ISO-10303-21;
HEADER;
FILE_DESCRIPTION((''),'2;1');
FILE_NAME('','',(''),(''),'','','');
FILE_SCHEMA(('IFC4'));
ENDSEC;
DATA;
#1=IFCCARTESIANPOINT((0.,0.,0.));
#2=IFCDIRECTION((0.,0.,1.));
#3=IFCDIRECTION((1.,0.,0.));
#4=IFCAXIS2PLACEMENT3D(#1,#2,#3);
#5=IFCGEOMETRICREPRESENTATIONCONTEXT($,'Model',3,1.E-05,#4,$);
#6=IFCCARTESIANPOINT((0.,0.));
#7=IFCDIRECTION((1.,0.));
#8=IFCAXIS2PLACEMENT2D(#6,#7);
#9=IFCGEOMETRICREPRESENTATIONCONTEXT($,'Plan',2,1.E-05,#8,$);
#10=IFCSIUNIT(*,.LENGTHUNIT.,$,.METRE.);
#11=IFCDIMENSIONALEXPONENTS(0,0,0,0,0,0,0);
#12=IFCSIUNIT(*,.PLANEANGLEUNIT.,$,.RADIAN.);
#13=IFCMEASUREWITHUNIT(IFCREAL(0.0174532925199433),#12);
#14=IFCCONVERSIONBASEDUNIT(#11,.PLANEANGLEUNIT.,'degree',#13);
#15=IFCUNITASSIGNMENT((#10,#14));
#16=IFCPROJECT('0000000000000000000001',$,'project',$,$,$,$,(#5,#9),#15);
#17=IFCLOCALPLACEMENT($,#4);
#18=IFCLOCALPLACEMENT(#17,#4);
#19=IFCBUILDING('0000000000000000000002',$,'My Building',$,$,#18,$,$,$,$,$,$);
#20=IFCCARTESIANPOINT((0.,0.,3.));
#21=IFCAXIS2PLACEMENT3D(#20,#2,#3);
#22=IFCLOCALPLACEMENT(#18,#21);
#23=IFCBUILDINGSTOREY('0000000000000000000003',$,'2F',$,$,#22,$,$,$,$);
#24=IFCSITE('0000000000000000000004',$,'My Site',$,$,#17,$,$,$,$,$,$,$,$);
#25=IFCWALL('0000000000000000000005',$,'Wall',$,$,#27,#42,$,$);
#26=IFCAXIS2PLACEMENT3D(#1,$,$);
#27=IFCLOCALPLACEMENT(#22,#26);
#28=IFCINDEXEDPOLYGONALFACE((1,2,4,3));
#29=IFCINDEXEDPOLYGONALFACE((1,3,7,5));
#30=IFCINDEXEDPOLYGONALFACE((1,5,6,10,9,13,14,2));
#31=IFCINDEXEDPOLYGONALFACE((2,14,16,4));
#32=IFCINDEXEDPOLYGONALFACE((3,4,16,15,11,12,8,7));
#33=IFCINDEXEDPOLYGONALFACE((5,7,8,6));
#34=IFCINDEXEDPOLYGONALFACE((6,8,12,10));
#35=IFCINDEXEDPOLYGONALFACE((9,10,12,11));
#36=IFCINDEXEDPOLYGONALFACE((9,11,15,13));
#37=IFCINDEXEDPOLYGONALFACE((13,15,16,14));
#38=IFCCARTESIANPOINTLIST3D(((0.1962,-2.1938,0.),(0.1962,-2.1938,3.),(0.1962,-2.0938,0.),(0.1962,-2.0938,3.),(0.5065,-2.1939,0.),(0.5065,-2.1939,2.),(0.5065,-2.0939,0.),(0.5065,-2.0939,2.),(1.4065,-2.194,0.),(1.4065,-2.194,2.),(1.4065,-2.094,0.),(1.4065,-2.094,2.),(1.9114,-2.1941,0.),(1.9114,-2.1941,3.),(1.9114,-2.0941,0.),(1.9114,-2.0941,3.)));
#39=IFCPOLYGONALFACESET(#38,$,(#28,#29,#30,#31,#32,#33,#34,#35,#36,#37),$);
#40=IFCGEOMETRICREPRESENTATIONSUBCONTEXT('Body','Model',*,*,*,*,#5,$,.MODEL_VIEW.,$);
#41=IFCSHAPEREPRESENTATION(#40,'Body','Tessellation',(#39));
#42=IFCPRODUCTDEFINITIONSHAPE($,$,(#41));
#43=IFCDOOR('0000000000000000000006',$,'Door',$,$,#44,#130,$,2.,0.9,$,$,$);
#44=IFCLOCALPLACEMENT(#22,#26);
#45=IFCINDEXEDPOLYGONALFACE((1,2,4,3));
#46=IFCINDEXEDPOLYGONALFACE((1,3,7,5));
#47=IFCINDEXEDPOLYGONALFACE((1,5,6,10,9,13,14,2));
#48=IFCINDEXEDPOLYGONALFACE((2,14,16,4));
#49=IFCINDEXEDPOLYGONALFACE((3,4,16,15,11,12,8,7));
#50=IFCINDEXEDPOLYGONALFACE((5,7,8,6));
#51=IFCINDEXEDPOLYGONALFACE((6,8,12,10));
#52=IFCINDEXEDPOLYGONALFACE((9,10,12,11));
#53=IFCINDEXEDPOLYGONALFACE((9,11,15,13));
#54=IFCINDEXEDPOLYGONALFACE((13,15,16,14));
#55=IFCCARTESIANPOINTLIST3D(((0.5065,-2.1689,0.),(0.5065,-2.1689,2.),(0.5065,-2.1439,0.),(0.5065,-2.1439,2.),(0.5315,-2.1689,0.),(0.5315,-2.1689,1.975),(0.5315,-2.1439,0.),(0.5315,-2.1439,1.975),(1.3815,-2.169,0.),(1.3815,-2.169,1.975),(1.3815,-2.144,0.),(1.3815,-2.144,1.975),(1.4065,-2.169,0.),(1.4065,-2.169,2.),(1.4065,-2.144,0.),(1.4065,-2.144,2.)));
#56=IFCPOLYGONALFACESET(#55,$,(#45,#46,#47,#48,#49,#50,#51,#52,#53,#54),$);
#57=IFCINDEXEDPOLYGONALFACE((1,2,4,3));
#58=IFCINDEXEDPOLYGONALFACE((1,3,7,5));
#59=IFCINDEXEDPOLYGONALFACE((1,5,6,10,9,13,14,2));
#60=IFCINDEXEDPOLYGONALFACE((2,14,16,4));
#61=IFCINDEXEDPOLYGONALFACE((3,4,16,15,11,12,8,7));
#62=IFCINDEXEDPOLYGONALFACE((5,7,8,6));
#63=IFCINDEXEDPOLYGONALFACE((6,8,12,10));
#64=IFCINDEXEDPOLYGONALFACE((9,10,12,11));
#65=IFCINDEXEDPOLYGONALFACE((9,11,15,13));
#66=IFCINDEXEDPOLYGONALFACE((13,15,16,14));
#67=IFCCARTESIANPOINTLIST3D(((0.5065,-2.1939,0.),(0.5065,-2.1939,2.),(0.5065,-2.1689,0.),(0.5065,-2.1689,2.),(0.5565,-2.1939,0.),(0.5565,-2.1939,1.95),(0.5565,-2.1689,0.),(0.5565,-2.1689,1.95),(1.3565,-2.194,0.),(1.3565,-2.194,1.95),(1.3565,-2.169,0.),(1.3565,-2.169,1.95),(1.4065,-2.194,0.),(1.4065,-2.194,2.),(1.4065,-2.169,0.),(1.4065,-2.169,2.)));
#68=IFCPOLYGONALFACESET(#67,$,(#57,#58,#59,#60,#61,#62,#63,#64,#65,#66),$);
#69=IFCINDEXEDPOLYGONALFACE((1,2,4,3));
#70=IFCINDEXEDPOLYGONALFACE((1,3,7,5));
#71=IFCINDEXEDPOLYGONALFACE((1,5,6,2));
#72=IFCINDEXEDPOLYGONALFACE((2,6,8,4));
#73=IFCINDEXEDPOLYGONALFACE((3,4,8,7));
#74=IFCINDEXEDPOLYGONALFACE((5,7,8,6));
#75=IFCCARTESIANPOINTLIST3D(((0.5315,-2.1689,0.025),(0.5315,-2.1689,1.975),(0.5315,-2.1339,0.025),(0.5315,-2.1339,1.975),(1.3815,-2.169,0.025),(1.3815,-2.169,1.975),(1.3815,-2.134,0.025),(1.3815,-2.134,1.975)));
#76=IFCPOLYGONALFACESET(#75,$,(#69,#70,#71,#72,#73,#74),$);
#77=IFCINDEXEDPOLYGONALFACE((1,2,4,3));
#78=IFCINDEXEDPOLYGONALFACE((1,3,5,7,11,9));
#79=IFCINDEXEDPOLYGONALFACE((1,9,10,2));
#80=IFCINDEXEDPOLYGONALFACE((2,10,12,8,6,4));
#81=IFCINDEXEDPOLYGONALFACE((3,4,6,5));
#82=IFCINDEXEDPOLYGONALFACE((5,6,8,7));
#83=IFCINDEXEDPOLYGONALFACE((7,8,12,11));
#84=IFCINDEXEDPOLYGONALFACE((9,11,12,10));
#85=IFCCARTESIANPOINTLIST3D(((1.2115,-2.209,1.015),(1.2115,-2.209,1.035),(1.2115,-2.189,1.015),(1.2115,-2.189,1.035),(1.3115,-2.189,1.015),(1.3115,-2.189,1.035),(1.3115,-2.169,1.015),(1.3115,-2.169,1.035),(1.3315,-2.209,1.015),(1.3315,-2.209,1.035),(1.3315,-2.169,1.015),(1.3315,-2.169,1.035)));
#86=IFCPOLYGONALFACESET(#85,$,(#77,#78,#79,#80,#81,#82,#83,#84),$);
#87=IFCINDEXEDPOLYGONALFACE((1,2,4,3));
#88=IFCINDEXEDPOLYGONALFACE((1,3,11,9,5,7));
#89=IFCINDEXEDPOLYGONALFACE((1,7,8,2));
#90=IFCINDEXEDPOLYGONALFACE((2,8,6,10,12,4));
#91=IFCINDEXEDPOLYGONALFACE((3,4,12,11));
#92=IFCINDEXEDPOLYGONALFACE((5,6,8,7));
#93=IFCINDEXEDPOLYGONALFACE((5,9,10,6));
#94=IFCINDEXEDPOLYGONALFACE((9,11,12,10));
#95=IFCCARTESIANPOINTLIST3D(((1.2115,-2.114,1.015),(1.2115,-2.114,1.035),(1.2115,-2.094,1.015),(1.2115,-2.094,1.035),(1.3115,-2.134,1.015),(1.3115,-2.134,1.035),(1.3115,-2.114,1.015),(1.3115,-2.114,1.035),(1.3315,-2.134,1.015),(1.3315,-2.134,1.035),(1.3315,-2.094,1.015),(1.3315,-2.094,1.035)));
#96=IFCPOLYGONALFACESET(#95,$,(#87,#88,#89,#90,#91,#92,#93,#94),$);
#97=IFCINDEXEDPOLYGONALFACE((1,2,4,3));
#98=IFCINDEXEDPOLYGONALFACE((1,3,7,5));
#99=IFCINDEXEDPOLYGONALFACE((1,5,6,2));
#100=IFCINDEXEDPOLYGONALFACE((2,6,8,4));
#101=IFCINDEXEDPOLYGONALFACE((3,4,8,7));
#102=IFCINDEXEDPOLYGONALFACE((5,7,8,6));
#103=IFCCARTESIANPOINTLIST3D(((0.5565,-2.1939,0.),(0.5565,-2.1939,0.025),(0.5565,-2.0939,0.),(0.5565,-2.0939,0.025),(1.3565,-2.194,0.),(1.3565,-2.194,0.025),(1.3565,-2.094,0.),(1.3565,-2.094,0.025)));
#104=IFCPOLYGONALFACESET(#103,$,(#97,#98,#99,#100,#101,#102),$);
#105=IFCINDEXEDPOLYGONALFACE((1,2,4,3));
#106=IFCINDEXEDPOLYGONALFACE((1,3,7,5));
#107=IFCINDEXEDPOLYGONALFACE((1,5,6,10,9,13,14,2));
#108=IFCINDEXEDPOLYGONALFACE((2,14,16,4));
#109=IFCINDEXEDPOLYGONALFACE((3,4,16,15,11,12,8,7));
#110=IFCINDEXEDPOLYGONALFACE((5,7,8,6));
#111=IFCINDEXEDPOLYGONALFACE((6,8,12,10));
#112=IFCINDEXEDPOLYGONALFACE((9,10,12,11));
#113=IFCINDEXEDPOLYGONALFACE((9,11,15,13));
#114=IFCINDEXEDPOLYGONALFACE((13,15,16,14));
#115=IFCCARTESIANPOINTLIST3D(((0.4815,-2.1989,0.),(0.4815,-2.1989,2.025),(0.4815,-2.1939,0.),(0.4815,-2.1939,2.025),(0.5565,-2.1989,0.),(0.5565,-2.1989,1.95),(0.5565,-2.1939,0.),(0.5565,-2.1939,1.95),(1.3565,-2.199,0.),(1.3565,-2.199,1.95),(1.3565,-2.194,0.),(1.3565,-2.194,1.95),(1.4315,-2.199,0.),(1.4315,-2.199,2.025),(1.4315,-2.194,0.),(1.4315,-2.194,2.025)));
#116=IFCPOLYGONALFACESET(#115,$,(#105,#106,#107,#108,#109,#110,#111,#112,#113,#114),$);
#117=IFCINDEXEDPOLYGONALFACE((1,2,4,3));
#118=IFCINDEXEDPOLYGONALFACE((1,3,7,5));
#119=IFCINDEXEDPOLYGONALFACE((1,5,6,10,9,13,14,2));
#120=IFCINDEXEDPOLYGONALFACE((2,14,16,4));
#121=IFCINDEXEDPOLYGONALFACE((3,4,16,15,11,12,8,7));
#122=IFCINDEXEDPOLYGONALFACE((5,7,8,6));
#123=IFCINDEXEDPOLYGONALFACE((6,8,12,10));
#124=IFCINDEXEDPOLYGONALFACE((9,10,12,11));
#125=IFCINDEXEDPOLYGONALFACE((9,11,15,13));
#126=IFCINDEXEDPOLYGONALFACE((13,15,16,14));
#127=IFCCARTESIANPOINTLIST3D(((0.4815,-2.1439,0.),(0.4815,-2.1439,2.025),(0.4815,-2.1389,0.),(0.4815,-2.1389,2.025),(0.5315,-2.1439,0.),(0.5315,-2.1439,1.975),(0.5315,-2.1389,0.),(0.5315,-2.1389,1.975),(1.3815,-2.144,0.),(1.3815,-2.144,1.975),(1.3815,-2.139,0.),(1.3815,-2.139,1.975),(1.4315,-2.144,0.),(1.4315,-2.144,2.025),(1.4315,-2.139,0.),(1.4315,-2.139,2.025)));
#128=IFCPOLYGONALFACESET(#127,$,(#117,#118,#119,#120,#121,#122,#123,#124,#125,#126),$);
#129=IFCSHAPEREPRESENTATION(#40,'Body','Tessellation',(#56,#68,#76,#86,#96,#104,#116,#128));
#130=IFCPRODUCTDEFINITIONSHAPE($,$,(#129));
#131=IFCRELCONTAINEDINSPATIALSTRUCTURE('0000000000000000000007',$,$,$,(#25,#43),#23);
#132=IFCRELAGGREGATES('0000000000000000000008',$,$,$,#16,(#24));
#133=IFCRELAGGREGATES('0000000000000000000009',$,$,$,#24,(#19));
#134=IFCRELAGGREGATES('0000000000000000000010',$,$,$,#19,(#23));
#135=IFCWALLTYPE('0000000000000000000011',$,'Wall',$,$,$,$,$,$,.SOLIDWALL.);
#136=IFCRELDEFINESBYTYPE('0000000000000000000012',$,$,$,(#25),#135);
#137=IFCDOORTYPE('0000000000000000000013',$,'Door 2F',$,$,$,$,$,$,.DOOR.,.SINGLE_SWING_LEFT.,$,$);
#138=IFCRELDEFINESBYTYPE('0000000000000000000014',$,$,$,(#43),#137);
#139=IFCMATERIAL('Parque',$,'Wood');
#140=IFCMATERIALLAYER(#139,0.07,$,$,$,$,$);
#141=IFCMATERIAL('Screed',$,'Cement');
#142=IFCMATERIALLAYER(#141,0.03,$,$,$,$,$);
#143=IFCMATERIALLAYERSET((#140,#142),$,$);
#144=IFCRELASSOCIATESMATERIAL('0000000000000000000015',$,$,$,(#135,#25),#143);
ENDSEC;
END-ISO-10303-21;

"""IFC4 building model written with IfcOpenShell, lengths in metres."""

from ifc_helpers import new_model, entity, si_unit, converted_unit, frame, origin_with_axes, origin_2d_with_axis, place, context, subcontext, project, spatial, line, indexed_curve, outline, extrude, shape, source, transform, mapped, material, layer, layer_set, layer_usage, type_object, type_shapes, element, fill, save


model = new_model("IFC4")

# Units and contexts
model_context = context("Model", 3, precision=1e-05, world=origin_with_axes())
plan_context = context("Plan", 2, precision=1e-05, world=origin_2d_with_axis())
body_context_1 = subcontext(model_context, "Body", "Model", "MODEL_VIEW")
body_context_2 = subcontext(plan_context, "Body", "Plan", "PLAN_VIEW")
ifc_project = project(units=[si_unit("LENGTHUNIT", "METRE"), converted_unit("PLANEANGLEUNIT", "degree", entity("IfcReal", 0.0174532925199433), si_unit("PLANEANGLEUNIT", "RADIAN"), dimensions=[0, 0, 0, 0, 0, 0, 0])], contexts=[model_context, plan_context])

# Site, building, storey
site_placement = place(None, origin_with_axes())
site = spatial("IfcSite", under=ifc_project, at=site_placement, Name="My Site")
building_placement = place(site_placement, origin_with_axes())
building = spatial("IfcBuilding", under=site, at=building_placement, Name="My Building")
storey_placement = place(building_placement, frame((0.0, 0.0, 3.0), z_axis=(0.0, 0.0, 1.0), x_axis=(1.0, 0.0, 0.0)))
storey = spatial("IfcBuildingStorey", under=building, at=storey_placement, Name="2F")

# Shared definitions
ifc_material_1 = material(Name="Parque", Category="Wood")
ifc_layer_1 = layer(ifc_material_1, 0.07)
ifc_material_2 = material(Name="Screed", Category="Cement")
ifc_layer_2 = layer(ifc_material_2, 0.03)
ifc_layer_set_1 = layer_set([ifc_layer_1, ifc_layer_2])
wall_type = type_object("IfcWallType", Name="Wall", PredefinedType="SOLIDWALL", material=ifc_layer_set_1)

# Wall, opening, door
ifc_layer_usage_1 = layer_usage(ifc_layer_set_1, "AXIS2", "POSITIVE", 0.0)
wall_1_placement = place(storey_placement, frame((0.1962, -2.1938, 0.0), z_axis=(0.0, 0.0, 1.0), x_axis=(1.0, -0.00013, 0.0)))
wall_1 = element("IfcWall", 1, at=wall_1_placement, inside=storey, type_object=wall_type, material=ifc_layer_usage_1, Name="Wall", context=body_context_1, shape_type="SweptSolid", body=[
    extrude(outline(indexed_curve([(0.0, 0.0), (0.0, 0.1), (1.7152, 0.1), (1.7152, 0.0)], segments=[line(1, 2, 3, 4, 1)])), origin_with_axes(), (0.0, 0.0, 1.0), 3.0),
])
shared_shape_1 = source(origin_with_axes(), body_context_1, "Body", "SweptSolid", [
    extrude(outline(indexed_curve([(0.0, 0.0), (0.9, 0.0), (0.9, 2.0), (0.0, 2.0)], segments=[line(1, 2, 3, 4, 1)])), frame((0.0, -0.6, 0.0), z_axis=(0.0, -1.0, 0.0), x_axis=(1.0, 0.0, 0.0)), (0.0, 0.0, -1.0), 1.2),
])
opening_1_placement = place(wall_1_placement, frame((0.3103, 0.0, 0.0), z_axis=(0.0, 0.0, 1.0), x_axis=(1.0, 0.0, 0.0)))
opening_1 = element("IfcOpeningElement", 2, at=opening_1_placement, cuts=wall_1, PredefinedType="OPENING", context=body_context_1, shape_type="MappedRepresentation", body=[
    mapped(shared_shape_1, transform((0.0, 0.0, 0.0), x_axis=(1.0, 0.0, 0.0), y_axis=(0.0, 1.0, 0.0), z_axis=(0.0, 0.0, 1.0), scale=1.0)),
])
door_type_1 = type_object("IfcDoorType", Name="Door 2F", OperationType="SINGLE_SWING_LEFT", PredefinedType="DOOR")
shared_shape_2 = source(origin_with_axes(), body_context_1, "Body", "SweptSolid", [
    extrude(outline(indexed_curve([(0.0, 0.0), (0.0, 2.0), (0.9, 2.0), (0.9, 0.0), (0.875, 0.0), (0.875, 1.975), (0.025, 1.975), (0.025, 0.0)], segments=[line(1, 2, 3, 4, 5, 6, 7, 8, 1)])), frame((0.0, 0.025, 0.0), z_axis=(0.0, -1.0, 0.0), x_axis=(1.0, 0.0, 0.0)), (0.0, 0.0, -1.0), 0.025),
    extrude(outline(indexed_curve([(0.0, 0.0), (0.0, 2.0), (0.9, 2.0), (0.9, 0.0), (0.85, 0.0), (0.85, 1.95), (0.05, 1.95), (0.05, 0.0)], segments=[line(1, 2, 3, 4, 5, 6, 7, 8, 1)])), frame((0.0, 0.0, 0.0), z_axis=(0.0, -1.0, 0.0), x_axis=(1.0, 0.0, 0.0)), (0.0, 0.0, -1.0), 0.025),
    extrude(outline(indexed_curve([(0.0, 0.0), (0.85, 0.0), (0.85, 0.035), (0.0, 0.035)], segments=[line(1, 2, 3, 4, 1)])), frame((0.025, 0.025, 0.025), z_axis=(0.0, 0.0, 1.0), x_axis=(1.0, 0.0, 0.0)), (0.0, 0.0, 1.0), 1.95),
    extrude(outline(indexed_curve([(0.0, 0.0), (0.0, -0.04), (-0.12, -0.04), (-0.12, -0.02), (-0.02, -0.02), (-0.02, 0.0)], segments=[line(1, 2, 3, 4, 5, 6, 1)])), frame((0.825, 0.025, 1.015), z_axis=(0.0, 0.0, 1.0), x_axis=(1.0, 0.0, 0.0)), (0.0, 0.0, 1.0), 0.02),
    extrude(outline(indexed_curve([(0.0, 0.0), (0.0, 0.04), (-0.12, 0.04), (-0.12, 0.02), (-0.02, 0.02), (-0.02, 0.0)], segments=[line(1, 2, 3, 4, 5, 6, 1)])), frame((0.825, 0.06, 1.015), z_axis=(0.0, 0.0, 1.0), x_axis=(1.0, 0.0, 0.0)), (0.0, 0.0, 1.0), 0.02),
    extrude(outline(indexed_curve([(0.0, 0.0), (0.8, 0.0), (0.8, 0.1), (0.0, 0.1)], segments=[line(1, 2, 3, 4, 1)])), frame((0.05, 0.0, 0.0), z_axis=(0.0, 0.0, 1.0), x_axis=(1.0, 0.0, 0.0)), (0.0, 0.0, 1.0), 0.025),
    extrude(outline(indexed_curve([(0.0, 0.0), (0.0, 2.025), (0.95, 2.025), (0.95, 0.0), (0.875, 0.0), (0.875, 1.95), (0.075, 1.95), (0.075, 0.0)], segments=[line(1, 2, 3, 4, 5, 6, 7, 8, 1)])), frame((-0.025, -0.005, 0.0), z_axis=(0.0, -1.0, 0.0), x_axis=(1.0, 0.0, 0.0)), (0.0, 0.0, -1.0), 0.005),
    extrude(outline(indexed_curve([(0.0, 0.0), (0.0, 2.025), (0.95, 2.025), (0.95, 0.0), (0.9, 0.0), (0.9, 1.975), (0.05, 1.975), (0.05, 0.0)], segments=[line(1, 2, 3, 4, 5, 6, 7, 8, 1)])), frame((-0.025, 0.05, 0.0), z_axis=(0.0, -1.0, 0.0), x_axis=(1.0, 0.0, 0.0)), (0.0, 0.0, -1.0), 0.005),
])
shared_shape_3 = source(origin_with_axes(), body_context_2, "Body", "Curve2D", [
    entity("IfcIndexedPolyCurve", entity("IfcCartesianPointList2D", [[0.0, 0.0], [0.0, 0.05], [0.025, 0.05], [0.025, 0.025], [0.05, 0.025], [0.05, 0.0]]), [entity("IfcLineIndex", [1, 2, 3, 4, 5, 6, 1])]),
    entity("IfcIndexedPolyCurve", entity("IfcCartesianPointList2D", [[0.9, 0.0], [0.9, 0.05], [0.875, 0.05], [0.875, 0.025], [0.85, 0.025], [0.85, 0.0]]), [entity("IfcLineIndex", [1, 2, 3, 4, 5, 6, 1])]),
    entity("IfcTrimmedCurve", entity("IfcEllipse", entity("IfcAxis2Placement2D", entity("IfcCartesianPoint", [0.06, 0.05]), entity("IfcDirection", [1.0, 0.0])), 0.815, 0.85), [entity("IfcCartesianPoint", [0.875, 0.05])], [entity("IfcCartesianPoint", [0.06, 0.9])], True, "CARTESIAN"),
    entity("IfcIndexedPolyCurve", entity("IfcCartesianPointList2D", [[0.025, 0.05], [0.06, 0.05], [0.06, 0.9], [0.025, 0.9]]), [entity("IfcLineIndex", [1, 2, 3, 4, 1])]),
])
type_shapes(door_type_1, [shared_shape_2, shared_shape_3])
door_1_placement = place(opening_1_placement, frame((0.0, 0.0, 0.0), z_axis=(0.0, 0.0, 1.0), x_axis=(1.0, 0.0, 0.0)))
door_1 = element("IfcDoor", 3, at=door_1_placement, inside=storey, type_object=door_type_1, Name="Door", OverallHeight=2.0, OverallWidth=0.9, shapes=[
    shape(body_context_1, "Body", "MappedRepresentation", [mapped(shared_shape_2, transform((0.0, 0.0, 0.0), x_axis=(1.0, 0.0, 0.0), y_axis=(0.0, 1.0, 0.0), z_axis=(0.0, 0.0, 1.0), scale=1.0))]),
    shape(body_context_2, "Body", "MappedRepresentation", [mapped(shared_shape_3, transform((0.0, 0.0, 0.0), x_axis=(1.0, 0.0, 0.0), y_axis=(0.0, 1.0, 0.0), z_axis=(0.0, 0.0, 1.0), scale=1.0))]),
])
fill(opening_1, door_1)

save(model, "model.ifc")
